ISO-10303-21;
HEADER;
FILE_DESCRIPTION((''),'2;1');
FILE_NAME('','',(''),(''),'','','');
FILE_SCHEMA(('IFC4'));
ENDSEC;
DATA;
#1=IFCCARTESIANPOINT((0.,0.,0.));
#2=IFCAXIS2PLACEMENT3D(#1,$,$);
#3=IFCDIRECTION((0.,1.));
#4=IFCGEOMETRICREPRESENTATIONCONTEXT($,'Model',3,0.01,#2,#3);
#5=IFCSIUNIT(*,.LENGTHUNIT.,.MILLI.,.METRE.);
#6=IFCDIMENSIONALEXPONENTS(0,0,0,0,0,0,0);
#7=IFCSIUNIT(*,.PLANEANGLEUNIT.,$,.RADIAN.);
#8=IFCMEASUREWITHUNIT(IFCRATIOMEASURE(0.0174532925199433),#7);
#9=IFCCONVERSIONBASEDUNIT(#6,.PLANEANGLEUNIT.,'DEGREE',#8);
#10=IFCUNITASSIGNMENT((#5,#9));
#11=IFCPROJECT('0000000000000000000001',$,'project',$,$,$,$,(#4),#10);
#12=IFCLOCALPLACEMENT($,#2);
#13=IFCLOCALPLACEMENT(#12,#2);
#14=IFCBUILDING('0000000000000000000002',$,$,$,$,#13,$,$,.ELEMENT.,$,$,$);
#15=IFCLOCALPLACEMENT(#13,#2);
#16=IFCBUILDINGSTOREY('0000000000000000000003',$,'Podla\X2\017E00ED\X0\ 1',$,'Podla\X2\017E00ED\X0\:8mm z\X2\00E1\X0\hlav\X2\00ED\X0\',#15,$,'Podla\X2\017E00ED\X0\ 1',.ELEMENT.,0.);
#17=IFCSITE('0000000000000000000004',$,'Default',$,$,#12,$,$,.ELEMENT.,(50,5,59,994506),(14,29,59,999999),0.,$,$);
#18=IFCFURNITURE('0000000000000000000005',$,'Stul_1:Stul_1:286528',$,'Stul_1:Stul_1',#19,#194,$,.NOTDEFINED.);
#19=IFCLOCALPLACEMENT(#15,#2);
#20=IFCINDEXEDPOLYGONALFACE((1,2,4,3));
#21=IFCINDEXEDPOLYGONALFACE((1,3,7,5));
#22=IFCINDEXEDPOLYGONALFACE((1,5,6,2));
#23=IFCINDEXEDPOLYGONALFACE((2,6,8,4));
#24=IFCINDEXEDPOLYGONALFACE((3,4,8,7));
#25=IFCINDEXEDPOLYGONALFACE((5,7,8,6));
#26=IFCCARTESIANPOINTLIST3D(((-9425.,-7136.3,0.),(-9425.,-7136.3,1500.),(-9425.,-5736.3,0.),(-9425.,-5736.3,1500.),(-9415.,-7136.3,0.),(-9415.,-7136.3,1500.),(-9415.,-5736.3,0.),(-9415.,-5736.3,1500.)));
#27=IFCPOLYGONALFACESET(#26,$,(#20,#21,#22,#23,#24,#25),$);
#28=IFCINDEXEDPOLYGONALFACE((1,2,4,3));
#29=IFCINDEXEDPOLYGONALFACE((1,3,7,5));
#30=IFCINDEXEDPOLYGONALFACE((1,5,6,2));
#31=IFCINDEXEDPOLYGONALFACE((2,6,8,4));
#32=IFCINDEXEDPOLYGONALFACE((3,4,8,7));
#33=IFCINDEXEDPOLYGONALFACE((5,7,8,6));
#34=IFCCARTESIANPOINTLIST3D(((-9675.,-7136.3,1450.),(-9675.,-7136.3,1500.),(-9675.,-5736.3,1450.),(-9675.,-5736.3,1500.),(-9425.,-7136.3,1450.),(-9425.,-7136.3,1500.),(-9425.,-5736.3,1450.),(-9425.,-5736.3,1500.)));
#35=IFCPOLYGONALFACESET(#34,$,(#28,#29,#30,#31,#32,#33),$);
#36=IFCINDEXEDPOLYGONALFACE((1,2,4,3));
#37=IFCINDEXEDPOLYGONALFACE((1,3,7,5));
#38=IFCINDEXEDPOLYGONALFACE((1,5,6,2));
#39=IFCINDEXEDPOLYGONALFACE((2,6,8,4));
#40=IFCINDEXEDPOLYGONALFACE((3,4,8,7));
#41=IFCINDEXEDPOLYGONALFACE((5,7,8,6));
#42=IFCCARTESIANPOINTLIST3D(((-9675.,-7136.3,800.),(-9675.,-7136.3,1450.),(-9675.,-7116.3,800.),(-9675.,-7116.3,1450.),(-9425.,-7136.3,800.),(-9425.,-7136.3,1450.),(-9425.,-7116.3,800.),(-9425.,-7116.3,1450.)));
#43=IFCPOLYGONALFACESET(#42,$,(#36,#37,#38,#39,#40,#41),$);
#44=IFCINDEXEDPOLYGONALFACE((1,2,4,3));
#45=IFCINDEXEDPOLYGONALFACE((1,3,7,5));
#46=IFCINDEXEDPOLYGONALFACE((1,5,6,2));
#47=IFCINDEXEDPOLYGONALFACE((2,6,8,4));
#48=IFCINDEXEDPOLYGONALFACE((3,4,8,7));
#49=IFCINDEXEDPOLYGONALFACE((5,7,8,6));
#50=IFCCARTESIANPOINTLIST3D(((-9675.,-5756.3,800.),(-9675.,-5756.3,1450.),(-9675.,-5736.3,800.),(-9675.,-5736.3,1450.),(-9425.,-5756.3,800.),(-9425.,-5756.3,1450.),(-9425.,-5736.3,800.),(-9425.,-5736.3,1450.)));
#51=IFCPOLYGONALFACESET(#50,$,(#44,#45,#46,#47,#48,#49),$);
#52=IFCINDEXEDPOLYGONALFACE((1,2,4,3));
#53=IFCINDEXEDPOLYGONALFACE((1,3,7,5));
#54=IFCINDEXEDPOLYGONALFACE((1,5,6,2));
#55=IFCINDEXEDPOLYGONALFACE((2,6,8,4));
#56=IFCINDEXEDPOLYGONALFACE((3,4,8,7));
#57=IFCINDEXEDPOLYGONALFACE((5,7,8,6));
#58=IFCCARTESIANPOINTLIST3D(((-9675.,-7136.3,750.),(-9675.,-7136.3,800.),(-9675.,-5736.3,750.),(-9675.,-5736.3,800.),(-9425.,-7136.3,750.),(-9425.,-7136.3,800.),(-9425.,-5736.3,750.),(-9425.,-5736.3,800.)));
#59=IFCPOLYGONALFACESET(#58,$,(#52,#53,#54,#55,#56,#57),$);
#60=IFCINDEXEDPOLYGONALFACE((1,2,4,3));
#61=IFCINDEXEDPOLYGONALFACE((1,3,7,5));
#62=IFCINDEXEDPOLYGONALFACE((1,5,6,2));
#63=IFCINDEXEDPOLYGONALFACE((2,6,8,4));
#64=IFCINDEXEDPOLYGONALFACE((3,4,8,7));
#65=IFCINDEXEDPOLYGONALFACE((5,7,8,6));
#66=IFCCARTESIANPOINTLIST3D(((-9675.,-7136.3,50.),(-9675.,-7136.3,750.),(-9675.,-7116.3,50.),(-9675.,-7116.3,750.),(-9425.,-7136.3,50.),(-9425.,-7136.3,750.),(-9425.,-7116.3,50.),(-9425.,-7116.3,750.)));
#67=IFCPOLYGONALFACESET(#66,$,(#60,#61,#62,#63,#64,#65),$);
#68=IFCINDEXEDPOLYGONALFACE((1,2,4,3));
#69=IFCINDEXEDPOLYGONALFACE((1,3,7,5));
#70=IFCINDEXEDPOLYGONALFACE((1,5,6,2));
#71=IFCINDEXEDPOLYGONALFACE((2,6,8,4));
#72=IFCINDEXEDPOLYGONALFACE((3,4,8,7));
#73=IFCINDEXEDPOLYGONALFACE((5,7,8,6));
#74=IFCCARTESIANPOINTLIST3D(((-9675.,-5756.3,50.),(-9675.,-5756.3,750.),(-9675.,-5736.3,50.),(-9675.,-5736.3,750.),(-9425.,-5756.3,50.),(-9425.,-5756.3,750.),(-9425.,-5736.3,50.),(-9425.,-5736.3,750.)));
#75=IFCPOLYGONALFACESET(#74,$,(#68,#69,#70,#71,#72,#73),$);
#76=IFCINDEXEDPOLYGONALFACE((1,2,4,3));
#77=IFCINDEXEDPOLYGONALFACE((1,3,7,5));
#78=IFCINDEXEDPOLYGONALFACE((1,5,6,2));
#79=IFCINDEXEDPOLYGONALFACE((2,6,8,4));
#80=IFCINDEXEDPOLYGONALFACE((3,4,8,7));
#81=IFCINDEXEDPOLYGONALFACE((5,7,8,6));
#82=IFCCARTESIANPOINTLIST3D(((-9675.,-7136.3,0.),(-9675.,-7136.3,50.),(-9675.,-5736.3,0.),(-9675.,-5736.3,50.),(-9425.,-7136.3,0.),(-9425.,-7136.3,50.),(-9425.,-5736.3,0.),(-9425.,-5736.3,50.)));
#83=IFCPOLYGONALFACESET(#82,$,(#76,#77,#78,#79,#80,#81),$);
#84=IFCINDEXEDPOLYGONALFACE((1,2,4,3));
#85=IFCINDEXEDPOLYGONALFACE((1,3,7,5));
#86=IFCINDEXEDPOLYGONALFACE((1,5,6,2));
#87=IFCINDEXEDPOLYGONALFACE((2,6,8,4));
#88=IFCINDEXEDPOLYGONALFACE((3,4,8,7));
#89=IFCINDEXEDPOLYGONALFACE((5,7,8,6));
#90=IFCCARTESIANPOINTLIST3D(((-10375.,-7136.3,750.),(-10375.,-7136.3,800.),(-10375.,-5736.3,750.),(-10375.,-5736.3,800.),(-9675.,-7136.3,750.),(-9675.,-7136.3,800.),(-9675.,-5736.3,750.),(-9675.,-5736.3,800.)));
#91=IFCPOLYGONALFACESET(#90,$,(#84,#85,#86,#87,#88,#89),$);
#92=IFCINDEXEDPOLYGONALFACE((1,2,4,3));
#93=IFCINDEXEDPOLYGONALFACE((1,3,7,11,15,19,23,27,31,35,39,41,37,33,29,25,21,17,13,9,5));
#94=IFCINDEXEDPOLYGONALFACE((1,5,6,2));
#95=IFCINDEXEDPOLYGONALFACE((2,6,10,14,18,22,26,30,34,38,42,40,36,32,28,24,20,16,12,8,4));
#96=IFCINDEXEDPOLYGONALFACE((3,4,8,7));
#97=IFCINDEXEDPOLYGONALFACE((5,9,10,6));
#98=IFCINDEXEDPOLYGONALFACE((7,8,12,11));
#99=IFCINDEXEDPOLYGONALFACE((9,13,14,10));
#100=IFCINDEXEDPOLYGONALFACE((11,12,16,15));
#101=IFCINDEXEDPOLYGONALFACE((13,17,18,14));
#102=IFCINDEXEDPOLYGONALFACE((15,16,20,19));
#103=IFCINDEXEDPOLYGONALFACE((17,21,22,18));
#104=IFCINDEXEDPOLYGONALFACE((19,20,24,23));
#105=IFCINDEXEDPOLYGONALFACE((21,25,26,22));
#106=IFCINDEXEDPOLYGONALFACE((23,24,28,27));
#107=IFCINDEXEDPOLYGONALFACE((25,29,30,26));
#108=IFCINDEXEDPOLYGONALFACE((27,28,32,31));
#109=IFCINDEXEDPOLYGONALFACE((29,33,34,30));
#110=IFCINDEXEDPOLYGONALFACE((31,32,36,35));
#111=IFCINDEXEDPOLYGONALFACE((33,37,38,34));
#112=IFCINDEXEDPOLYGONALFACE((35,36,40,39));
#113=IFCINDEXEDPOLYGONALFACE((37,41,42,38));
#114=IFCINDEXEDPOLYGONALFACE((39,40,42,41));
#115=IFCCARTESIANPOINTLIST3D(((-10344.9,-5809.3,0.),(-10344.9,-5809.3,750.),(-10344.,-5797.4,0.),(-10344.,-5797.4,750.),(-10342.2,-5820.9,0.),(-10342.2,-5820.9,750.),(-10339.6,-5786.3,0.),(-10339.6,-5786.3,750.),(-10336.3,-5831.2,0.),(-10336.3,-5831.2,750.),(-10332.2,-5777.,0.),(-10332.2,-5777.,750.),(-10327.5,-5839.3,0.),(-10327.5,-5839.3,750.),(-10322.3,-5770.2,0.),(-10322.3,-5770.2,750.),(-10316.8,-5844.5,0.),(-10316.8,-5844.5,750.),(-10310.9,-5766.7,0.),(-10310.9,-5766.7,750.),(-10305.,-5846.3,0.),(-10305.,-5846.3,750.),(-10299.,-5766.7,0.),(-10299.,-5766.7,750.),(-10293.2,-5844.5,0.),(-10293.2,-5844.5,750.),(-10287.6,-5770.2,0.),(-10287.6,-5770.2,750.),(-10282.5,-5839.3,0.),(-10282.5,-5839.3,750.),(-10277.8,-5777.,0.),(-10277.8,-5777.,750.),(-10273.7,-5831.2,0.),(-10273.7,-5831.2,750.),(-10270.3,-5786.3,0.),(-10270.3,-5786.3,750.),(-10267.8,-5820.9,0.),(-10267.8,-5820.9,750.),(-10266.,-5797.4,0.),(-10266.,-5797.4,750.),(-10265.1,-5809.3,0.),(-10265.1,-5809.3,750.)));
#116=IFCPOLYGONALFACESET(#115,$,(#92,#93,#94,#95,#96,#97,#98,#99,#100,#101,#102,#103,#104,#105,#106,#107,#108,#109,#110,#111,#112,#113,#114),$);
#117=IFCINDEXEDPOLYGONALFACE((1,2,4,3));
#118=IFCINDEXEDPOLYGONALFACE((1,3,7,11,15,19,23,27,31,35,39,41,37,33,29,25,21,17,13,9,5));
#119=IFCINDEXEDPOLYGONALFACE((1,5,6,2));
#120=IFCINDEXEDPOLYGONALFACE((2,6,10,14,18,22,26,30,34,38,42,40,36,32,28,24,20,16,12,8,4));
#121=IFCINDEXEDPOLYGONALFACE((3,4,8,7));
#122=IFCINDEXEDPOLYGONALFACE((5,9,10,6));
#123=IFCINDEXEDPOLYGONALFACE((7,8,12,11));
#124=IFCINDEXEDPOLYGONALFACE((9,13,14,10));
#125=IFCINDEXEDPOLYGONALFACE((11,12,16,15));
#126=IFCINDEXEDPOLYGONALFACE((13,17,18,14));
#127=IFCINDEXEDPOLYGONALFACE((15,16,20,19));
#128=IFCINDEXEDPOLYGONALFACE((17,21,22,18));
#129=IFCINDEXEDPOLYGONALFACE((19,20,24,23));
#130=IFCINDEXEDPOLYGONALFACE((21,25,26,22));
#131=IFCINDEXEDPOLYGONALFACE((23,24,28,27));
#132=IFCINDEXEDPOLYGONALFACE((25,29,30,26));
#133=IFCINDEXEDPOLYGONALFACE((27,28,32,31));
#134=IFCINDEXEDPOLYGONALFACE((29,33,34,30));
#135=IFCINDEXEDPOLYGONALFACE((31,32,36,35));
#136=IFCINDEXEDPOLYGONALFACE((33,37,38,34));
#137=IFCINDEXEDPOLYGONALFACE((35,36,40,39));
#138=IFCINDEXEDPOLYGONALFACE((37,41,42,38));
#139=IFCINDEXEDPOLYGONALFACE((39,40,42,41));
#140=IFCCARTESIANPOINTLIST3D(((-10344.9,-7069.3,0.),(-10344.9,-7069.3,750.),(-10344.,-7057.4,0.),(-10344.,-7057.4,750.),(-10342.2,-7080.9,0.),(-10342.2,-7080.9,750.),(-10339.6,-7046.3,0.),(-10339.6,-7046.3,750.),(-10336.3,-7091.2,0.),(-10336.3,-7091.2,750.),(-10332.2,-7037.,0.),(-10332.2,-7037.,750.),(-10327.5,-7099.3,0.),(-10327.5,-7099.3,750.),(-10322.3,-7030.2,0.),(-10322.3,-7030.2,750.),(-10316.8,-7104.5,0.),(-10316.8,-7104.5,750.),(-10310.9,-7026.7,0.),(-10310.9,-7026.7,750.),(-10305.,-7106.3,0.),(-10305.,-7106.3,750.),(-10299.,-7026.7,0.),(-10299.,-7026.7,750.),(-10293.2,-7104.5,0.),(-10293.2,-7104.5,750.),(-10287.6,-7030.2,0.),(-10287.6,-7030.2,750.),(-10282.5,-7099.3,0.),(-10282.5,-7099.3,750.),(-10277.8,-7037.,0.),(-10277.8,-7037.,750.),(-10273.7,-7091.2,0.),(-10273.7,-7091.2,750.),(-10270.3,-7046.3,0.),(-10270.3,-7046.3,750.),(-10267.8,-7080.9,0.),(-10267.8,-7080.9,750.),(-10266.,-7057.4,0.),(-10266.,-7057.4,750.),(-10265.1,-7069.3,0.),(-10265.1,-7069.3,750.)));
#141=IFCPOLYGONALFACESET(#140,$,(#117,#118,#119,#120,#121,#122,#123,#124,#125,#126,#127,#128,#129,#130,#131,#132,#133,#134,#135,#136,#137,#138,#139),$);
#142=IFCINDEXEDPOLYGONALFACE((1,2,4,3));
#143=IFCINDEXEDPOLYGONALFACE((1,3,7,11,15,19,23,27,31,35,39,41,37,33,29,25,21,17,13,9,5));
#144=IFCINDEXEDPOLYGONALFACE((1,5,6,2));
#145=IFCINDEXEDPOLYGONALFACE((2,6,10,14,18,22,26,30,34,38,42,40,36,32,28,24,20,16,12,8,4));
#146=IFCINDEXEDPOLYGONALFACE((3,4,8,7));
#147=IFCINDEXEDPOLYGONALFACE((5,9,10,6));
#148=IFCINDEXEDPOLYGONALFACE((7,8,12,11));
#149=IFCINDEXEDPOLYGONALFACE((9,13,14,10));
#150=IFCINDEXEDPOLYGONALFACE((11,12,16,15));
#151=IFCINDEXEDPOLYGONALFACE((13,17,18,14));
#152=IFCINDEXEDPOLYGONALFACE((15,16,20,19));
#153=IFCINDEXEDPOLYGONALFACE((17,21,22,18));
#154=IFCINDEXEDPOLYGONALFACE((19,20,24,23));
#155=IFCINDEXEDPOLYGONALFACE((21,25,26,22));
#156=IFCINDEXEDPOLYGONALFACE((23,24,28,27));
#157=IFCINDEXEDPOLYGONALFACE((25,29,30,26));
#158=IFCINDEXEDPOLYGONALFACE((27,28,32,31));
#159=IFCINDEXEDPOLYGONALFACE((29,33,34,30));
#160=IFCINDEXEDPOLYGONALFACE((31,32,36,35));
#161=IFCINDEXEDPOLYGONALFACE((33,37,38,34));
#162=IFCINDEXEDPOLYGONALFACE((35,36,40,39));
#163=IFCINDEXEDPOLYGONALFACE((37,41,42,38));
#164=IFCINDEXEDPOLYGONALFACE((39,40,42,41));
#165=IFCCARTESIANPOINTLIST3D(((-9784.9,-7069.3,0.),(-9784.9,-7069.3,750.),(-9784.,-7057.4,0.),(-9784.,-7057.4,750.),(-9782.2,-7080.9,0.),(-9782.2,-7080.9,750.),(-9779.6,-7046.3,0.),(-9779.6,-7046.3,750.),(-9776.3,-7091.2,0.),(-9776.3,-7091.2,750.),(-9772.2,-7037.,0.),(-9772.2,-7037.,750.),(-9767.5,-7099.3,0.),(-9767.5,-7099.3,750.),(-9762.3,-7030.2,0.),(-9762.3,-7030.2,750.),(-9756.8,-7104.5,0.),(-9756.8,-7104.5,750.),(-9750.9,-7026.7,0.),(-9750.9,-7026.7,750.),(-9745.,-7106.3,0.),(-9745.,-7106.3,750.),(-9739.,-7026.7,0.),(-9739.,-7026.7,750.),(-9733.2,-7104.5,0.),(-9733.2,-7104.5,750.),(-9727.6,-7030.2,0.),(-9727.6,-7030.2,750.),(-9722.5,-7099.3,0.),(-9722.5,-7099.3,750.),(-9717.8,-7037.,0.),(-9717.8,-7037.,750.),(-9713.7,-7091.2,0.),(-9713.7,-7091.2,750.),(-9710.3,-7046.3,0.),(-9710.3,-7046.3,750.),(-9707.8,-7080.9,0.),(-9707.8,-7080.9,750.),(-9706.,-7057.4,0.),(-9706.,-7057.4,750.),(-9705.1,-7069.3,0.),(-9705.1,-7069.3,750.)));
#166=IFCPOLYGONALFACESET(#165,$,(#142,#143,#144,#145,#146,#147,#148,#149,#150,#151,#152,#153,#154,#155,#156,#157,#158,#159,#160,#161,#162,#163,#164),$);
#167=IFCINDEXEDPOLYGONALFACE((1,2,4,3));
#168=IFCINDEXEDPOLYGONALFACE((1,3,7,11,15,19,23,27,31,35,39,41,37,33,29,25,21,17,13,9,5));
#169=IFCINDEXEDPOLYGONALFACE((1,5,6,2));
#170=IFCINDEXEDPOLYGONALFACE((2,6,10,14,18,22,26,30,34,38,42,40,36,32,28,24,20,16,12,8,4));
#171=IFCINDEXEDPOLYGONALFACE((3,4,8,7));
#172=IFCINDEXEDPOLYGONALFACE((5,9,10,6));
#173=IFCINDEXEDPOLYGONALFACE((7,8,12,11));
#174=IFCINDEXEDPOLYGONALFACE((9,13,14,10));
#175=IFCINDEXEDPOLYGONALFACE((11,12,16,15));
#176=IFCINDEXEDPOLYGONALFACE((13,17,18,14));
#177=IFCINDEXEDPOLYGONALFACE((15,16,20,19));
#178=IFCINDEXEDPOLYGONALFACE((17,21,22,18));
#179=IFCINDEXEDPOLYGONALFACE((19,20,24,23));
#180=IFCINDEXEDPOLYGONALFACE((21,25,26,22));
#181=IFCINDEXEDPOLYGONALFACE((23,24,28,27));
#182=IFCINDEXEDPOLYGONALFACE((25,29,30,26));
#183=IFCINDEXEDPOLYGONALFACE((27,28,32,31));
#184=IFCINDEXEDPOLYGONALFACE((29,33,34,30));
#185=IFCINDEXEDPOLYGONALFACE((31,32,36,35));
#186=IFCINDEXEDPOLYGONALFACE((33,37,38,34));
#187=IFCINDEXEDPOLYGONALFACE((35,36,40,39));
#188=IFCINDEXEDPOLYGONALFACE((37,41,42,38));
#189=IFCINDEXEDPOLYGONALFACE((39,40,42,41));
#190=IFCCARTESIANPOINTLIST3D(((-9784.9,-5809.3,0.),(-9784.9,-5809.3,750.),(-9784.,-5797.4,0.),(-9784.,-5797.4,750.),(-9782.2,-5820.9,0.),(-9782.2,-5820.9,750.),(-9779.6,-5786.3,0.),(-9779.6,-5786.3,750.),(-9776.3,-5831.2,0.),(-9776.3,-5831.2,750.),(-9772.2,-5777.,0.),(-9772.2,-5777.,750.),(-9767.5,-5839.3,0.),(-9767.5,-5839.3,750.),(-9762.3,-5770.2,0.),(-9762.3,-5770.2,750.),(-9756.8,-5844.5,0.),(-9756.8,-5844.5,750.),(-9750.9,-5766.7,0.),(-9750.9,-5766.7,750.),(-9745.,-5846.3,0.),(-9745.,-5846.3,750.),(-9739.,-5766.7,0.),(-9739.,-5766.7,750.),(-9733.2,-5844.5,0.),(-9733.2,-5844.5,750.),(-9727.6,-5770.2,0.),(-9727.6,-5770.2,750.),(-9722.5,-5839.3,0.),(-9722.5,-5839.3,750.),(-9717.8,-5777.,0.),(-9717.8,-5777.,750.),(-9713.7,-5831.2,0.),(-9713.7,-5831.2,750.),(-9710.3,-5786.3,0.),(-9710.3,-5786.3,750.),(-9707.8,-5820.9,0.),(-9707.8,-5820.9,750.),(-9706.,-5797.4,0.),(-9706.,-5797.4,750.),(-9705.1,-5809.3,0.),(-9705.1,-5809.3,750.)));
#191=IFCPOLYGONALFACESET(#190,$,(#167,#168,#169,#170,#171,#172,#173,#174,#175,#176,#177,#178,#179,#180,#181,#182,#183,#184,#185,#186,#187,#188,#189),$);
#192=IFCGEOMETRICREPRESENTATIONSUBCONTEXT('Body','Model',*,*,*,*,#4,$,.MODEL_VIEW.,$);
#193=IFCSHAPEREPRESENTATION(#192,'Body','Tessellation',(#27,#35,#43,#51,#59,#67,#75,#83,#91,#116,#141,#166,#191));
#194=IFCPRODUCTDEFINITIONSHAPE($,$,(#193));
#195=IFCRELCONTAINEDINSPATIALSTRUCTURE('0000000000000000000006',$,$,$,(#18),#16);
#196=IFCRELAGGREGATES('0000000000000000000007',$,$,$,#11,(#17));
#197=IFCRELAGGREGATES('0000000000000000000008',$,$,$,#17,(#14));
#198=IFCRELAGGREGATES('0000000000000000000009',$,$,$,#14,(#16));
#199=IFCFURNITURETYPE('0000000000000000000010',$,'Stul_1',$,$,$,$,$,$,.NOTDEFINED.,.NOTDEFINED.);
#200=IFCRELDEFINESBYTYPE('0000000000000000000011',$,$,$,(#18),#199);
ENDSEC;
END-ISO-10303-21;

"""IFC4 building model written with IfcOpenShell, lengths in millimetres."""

from ifc_helpers import new_model, entity, si_unit, converted_unit, direction, frame, frame_2d, origin, origin_2d_with_axis, place, context, subcontext, project, spatial, rectangle, circle, extrude, source, transform, mapped, type_object, type_shapes, element, save


model = new_model("IFC4")

# Units and contexts
model_context = context("Model", 3, precision=0.01, world=origin(), true_north=direction((0.0, 1.0)))
body_context = subcontext(model_context, "Body", "Model", "MODEL_VIEW")
ifc_project = project(units=[si_unit("LENGTHUNIT", "METRE", prefix="MILLI"), converted_unit("PLANEANGLEUNIT", "DEGREE", entity("IfcRatioMeasure", 0.0174532925199433), si_unit("PLANEANGLEUNIT", "RADIAN"), dimensions=[0, 0, 0, 0, 0, 0, 0])], contexts=[model_context])

# Site, building, storey
site_placement = place(None, origin())
site = spatial("IfcSite", under=ifc_project, at=site_placement, Name="Default", CompositionType="ELEMENT", RefLatitude=(50, 5, 59, 994506), RefLongitude=(14, 29, 59, 999999), RefElevation=0.0)
building_placement = place(site_placement, origin())
building = spatial("IfcBuilding", under=site, at=building_placement, CompositionType="ELEMENT")
storey_placement = place(building_placement, origin())
storey = spatial("IfcBuildingStorey", under=building, at=storey_placement, Name="Podlaží 1", ObjectType="Podlaží:8mm záhlaví", LongName="Podlaží 1", CompositionType="ELEMENT", Elevation=0.0)

# Furniture
furniture_type = type_object("IfcFurnitureType", Name="Stul_1", AssemblyPlace="NOTDEFINED", PredefinedType="NOTDEFINED")
shared_shape_1 = source(origin(), body_context, "Body", "SweptSolid", [
    extrude(rectangle(XDim=1400.0, YDim=10.0, at=origin_2d_with_axis()), frame((0.0, 605.0, 0.0), z_axis=(0.0, 0.0, 1.0), x_axis=(-1.0, 0.0, 0.0)), (0.0, 0.0, 1.0), 1500.0),
    extrude(rectangle(XDim=1400.0, YDim=250.0, at=frame_2d((0.0, 0.0), x_axis=(1.0, 0.0))), frame((0.0, 475.0, 1450.0), z_axis=(0.0, 0.0, 1.0), x_axis=(-1.0, 0.0, 0.0)), (0.0, 0.0, 1.0), 50.0),
    extrude(rectangle(XDim=20.0, YDim=250.0, at=origin_2d_with_axis()), frame((690.0, 475.0, 800.0), z_axis=(0.0, 0.0, 1.0), x_axis=(-1.0, 0.0, 0.0)), (0.0, 0.0, 1.0), 650.0),
    extrude(rectangle(XDim=20.0, YDim=250.0, at=frame_2d((0.0, 0.0), x_axis=(1.0, 0.0))), frame((-690.0, 475.0, 800.0), z_axis=(0.0, 0.0, 1.0), x_axis=(-1.0, 0.0, 0.0)), (0.0, 0.0, 1.0), 650.0),
    extrude(rectangle(XDim=1400.0, YDim=250.0, at=origin_2d_with_axis()), frame((0.0, 475.0, 750.0), z_axis=(0.0, 0.0, 1.0), x_axis=(-1.0, 0.0, 0.0)), (0.0, 0.0, 1.0), 50.0),
    extrude(rectangle(XDim=20.0, YDim=250.0, at=origin_2d_with_axis()), frame((690.0, 475.0, 50.0), z_axis=(0.0, 0.0, 1.0), x_axis=(-1.0, 0.0, 0.0)), (0.0, 0.0, 1.0), 700.0),
    extrude(rectangle(XDim=20.0, YDim=250.0, at=frame_2d((0.0, 0.0), x_axis=(1.0, 0.0))), frame((-690.0, 475.0, 50.0), z_axis=(0.0, 0.0, 1.0), x_axis=(-1.0, 0.0, 0.0)), (0.0, 0.0, 1.0), 700.0),
    extrude(rectangle(XDim=1400.0, YDim=250.0, at=origin_2d_with_axis()), frame((0.0, 475.0, 0.0), z_axis=(0.0, 0.0, 1.0), x_axis=(-1.0, 0.0, 0.0)), (0.0, 0.0, 1.0), 50.0),
    extrude(rectangle(XDim=1400.0, YDim=700.0, at=origin_2d_with_axis()), frame((0.0, 0.0, 750.0), z_axis=(0.0, 0.0, 1.0), x_axis=(-1.0, 0.0, 0.0)), (0.0, 0.0, 1.0), 50.0),
    extrude(circle(Radius=40.0, at=frame_2d((0.0, 0.0), x_axis=(1.0, 0.0))), frame((-630.0, -280.0, 0.0)), (0.0, 0.0, 1.0), 750.0),
    extrude(circle(Radius=40.0, at=frame_2d((0.0, 0.0), x_axis=(1.0, 0.0))), frame((630.0, -280.0, 0.0)), (0.0, 0.0, 1.0), 750.0),
    extrude(circle(Radius=40.0, at=frame_2d((0.0, 0.0), x_axis=(1.0, 0.0))), frame((630.0, 280.0, 0.0)), (0.0, 0.0, 1.0), 750.0),
    extrude(circle(Radius=40.0, at=frame_2d((0.0, 0.0), x_axis=(1.0, 0.0))), frame((-630.0, 280.0, 0.0)), (0.0, 0.0, 1.0), 750.0),
])
type_shapes(furniture_type, [shared_shape_1])
for number, where, z_axis, x_axis, name in (
    (1, (-10025.0, -6436.3, 0.0), (0.0, 0.0, 1.0), (0.0, -1.0, 0.0), "Stul_1:Stul_1:286528"),
):
    element("IfcFurniture", number, at=place(storey_placement, frame(where, z_axis=z_axis, x_axis=x_axis)), inside=storey, type_object=furniture_type, Name=name, ObjectType="Stul_1:Stul_1", PredefinedType="NOTDEFINED", context=body_context, shape_type="MappedRepresentation", body=[
        mapped(shared_shape_1, transform((0.0, 0.0, 0.0), scale=1.0)),
    ])

save(model, "model.ifc")
